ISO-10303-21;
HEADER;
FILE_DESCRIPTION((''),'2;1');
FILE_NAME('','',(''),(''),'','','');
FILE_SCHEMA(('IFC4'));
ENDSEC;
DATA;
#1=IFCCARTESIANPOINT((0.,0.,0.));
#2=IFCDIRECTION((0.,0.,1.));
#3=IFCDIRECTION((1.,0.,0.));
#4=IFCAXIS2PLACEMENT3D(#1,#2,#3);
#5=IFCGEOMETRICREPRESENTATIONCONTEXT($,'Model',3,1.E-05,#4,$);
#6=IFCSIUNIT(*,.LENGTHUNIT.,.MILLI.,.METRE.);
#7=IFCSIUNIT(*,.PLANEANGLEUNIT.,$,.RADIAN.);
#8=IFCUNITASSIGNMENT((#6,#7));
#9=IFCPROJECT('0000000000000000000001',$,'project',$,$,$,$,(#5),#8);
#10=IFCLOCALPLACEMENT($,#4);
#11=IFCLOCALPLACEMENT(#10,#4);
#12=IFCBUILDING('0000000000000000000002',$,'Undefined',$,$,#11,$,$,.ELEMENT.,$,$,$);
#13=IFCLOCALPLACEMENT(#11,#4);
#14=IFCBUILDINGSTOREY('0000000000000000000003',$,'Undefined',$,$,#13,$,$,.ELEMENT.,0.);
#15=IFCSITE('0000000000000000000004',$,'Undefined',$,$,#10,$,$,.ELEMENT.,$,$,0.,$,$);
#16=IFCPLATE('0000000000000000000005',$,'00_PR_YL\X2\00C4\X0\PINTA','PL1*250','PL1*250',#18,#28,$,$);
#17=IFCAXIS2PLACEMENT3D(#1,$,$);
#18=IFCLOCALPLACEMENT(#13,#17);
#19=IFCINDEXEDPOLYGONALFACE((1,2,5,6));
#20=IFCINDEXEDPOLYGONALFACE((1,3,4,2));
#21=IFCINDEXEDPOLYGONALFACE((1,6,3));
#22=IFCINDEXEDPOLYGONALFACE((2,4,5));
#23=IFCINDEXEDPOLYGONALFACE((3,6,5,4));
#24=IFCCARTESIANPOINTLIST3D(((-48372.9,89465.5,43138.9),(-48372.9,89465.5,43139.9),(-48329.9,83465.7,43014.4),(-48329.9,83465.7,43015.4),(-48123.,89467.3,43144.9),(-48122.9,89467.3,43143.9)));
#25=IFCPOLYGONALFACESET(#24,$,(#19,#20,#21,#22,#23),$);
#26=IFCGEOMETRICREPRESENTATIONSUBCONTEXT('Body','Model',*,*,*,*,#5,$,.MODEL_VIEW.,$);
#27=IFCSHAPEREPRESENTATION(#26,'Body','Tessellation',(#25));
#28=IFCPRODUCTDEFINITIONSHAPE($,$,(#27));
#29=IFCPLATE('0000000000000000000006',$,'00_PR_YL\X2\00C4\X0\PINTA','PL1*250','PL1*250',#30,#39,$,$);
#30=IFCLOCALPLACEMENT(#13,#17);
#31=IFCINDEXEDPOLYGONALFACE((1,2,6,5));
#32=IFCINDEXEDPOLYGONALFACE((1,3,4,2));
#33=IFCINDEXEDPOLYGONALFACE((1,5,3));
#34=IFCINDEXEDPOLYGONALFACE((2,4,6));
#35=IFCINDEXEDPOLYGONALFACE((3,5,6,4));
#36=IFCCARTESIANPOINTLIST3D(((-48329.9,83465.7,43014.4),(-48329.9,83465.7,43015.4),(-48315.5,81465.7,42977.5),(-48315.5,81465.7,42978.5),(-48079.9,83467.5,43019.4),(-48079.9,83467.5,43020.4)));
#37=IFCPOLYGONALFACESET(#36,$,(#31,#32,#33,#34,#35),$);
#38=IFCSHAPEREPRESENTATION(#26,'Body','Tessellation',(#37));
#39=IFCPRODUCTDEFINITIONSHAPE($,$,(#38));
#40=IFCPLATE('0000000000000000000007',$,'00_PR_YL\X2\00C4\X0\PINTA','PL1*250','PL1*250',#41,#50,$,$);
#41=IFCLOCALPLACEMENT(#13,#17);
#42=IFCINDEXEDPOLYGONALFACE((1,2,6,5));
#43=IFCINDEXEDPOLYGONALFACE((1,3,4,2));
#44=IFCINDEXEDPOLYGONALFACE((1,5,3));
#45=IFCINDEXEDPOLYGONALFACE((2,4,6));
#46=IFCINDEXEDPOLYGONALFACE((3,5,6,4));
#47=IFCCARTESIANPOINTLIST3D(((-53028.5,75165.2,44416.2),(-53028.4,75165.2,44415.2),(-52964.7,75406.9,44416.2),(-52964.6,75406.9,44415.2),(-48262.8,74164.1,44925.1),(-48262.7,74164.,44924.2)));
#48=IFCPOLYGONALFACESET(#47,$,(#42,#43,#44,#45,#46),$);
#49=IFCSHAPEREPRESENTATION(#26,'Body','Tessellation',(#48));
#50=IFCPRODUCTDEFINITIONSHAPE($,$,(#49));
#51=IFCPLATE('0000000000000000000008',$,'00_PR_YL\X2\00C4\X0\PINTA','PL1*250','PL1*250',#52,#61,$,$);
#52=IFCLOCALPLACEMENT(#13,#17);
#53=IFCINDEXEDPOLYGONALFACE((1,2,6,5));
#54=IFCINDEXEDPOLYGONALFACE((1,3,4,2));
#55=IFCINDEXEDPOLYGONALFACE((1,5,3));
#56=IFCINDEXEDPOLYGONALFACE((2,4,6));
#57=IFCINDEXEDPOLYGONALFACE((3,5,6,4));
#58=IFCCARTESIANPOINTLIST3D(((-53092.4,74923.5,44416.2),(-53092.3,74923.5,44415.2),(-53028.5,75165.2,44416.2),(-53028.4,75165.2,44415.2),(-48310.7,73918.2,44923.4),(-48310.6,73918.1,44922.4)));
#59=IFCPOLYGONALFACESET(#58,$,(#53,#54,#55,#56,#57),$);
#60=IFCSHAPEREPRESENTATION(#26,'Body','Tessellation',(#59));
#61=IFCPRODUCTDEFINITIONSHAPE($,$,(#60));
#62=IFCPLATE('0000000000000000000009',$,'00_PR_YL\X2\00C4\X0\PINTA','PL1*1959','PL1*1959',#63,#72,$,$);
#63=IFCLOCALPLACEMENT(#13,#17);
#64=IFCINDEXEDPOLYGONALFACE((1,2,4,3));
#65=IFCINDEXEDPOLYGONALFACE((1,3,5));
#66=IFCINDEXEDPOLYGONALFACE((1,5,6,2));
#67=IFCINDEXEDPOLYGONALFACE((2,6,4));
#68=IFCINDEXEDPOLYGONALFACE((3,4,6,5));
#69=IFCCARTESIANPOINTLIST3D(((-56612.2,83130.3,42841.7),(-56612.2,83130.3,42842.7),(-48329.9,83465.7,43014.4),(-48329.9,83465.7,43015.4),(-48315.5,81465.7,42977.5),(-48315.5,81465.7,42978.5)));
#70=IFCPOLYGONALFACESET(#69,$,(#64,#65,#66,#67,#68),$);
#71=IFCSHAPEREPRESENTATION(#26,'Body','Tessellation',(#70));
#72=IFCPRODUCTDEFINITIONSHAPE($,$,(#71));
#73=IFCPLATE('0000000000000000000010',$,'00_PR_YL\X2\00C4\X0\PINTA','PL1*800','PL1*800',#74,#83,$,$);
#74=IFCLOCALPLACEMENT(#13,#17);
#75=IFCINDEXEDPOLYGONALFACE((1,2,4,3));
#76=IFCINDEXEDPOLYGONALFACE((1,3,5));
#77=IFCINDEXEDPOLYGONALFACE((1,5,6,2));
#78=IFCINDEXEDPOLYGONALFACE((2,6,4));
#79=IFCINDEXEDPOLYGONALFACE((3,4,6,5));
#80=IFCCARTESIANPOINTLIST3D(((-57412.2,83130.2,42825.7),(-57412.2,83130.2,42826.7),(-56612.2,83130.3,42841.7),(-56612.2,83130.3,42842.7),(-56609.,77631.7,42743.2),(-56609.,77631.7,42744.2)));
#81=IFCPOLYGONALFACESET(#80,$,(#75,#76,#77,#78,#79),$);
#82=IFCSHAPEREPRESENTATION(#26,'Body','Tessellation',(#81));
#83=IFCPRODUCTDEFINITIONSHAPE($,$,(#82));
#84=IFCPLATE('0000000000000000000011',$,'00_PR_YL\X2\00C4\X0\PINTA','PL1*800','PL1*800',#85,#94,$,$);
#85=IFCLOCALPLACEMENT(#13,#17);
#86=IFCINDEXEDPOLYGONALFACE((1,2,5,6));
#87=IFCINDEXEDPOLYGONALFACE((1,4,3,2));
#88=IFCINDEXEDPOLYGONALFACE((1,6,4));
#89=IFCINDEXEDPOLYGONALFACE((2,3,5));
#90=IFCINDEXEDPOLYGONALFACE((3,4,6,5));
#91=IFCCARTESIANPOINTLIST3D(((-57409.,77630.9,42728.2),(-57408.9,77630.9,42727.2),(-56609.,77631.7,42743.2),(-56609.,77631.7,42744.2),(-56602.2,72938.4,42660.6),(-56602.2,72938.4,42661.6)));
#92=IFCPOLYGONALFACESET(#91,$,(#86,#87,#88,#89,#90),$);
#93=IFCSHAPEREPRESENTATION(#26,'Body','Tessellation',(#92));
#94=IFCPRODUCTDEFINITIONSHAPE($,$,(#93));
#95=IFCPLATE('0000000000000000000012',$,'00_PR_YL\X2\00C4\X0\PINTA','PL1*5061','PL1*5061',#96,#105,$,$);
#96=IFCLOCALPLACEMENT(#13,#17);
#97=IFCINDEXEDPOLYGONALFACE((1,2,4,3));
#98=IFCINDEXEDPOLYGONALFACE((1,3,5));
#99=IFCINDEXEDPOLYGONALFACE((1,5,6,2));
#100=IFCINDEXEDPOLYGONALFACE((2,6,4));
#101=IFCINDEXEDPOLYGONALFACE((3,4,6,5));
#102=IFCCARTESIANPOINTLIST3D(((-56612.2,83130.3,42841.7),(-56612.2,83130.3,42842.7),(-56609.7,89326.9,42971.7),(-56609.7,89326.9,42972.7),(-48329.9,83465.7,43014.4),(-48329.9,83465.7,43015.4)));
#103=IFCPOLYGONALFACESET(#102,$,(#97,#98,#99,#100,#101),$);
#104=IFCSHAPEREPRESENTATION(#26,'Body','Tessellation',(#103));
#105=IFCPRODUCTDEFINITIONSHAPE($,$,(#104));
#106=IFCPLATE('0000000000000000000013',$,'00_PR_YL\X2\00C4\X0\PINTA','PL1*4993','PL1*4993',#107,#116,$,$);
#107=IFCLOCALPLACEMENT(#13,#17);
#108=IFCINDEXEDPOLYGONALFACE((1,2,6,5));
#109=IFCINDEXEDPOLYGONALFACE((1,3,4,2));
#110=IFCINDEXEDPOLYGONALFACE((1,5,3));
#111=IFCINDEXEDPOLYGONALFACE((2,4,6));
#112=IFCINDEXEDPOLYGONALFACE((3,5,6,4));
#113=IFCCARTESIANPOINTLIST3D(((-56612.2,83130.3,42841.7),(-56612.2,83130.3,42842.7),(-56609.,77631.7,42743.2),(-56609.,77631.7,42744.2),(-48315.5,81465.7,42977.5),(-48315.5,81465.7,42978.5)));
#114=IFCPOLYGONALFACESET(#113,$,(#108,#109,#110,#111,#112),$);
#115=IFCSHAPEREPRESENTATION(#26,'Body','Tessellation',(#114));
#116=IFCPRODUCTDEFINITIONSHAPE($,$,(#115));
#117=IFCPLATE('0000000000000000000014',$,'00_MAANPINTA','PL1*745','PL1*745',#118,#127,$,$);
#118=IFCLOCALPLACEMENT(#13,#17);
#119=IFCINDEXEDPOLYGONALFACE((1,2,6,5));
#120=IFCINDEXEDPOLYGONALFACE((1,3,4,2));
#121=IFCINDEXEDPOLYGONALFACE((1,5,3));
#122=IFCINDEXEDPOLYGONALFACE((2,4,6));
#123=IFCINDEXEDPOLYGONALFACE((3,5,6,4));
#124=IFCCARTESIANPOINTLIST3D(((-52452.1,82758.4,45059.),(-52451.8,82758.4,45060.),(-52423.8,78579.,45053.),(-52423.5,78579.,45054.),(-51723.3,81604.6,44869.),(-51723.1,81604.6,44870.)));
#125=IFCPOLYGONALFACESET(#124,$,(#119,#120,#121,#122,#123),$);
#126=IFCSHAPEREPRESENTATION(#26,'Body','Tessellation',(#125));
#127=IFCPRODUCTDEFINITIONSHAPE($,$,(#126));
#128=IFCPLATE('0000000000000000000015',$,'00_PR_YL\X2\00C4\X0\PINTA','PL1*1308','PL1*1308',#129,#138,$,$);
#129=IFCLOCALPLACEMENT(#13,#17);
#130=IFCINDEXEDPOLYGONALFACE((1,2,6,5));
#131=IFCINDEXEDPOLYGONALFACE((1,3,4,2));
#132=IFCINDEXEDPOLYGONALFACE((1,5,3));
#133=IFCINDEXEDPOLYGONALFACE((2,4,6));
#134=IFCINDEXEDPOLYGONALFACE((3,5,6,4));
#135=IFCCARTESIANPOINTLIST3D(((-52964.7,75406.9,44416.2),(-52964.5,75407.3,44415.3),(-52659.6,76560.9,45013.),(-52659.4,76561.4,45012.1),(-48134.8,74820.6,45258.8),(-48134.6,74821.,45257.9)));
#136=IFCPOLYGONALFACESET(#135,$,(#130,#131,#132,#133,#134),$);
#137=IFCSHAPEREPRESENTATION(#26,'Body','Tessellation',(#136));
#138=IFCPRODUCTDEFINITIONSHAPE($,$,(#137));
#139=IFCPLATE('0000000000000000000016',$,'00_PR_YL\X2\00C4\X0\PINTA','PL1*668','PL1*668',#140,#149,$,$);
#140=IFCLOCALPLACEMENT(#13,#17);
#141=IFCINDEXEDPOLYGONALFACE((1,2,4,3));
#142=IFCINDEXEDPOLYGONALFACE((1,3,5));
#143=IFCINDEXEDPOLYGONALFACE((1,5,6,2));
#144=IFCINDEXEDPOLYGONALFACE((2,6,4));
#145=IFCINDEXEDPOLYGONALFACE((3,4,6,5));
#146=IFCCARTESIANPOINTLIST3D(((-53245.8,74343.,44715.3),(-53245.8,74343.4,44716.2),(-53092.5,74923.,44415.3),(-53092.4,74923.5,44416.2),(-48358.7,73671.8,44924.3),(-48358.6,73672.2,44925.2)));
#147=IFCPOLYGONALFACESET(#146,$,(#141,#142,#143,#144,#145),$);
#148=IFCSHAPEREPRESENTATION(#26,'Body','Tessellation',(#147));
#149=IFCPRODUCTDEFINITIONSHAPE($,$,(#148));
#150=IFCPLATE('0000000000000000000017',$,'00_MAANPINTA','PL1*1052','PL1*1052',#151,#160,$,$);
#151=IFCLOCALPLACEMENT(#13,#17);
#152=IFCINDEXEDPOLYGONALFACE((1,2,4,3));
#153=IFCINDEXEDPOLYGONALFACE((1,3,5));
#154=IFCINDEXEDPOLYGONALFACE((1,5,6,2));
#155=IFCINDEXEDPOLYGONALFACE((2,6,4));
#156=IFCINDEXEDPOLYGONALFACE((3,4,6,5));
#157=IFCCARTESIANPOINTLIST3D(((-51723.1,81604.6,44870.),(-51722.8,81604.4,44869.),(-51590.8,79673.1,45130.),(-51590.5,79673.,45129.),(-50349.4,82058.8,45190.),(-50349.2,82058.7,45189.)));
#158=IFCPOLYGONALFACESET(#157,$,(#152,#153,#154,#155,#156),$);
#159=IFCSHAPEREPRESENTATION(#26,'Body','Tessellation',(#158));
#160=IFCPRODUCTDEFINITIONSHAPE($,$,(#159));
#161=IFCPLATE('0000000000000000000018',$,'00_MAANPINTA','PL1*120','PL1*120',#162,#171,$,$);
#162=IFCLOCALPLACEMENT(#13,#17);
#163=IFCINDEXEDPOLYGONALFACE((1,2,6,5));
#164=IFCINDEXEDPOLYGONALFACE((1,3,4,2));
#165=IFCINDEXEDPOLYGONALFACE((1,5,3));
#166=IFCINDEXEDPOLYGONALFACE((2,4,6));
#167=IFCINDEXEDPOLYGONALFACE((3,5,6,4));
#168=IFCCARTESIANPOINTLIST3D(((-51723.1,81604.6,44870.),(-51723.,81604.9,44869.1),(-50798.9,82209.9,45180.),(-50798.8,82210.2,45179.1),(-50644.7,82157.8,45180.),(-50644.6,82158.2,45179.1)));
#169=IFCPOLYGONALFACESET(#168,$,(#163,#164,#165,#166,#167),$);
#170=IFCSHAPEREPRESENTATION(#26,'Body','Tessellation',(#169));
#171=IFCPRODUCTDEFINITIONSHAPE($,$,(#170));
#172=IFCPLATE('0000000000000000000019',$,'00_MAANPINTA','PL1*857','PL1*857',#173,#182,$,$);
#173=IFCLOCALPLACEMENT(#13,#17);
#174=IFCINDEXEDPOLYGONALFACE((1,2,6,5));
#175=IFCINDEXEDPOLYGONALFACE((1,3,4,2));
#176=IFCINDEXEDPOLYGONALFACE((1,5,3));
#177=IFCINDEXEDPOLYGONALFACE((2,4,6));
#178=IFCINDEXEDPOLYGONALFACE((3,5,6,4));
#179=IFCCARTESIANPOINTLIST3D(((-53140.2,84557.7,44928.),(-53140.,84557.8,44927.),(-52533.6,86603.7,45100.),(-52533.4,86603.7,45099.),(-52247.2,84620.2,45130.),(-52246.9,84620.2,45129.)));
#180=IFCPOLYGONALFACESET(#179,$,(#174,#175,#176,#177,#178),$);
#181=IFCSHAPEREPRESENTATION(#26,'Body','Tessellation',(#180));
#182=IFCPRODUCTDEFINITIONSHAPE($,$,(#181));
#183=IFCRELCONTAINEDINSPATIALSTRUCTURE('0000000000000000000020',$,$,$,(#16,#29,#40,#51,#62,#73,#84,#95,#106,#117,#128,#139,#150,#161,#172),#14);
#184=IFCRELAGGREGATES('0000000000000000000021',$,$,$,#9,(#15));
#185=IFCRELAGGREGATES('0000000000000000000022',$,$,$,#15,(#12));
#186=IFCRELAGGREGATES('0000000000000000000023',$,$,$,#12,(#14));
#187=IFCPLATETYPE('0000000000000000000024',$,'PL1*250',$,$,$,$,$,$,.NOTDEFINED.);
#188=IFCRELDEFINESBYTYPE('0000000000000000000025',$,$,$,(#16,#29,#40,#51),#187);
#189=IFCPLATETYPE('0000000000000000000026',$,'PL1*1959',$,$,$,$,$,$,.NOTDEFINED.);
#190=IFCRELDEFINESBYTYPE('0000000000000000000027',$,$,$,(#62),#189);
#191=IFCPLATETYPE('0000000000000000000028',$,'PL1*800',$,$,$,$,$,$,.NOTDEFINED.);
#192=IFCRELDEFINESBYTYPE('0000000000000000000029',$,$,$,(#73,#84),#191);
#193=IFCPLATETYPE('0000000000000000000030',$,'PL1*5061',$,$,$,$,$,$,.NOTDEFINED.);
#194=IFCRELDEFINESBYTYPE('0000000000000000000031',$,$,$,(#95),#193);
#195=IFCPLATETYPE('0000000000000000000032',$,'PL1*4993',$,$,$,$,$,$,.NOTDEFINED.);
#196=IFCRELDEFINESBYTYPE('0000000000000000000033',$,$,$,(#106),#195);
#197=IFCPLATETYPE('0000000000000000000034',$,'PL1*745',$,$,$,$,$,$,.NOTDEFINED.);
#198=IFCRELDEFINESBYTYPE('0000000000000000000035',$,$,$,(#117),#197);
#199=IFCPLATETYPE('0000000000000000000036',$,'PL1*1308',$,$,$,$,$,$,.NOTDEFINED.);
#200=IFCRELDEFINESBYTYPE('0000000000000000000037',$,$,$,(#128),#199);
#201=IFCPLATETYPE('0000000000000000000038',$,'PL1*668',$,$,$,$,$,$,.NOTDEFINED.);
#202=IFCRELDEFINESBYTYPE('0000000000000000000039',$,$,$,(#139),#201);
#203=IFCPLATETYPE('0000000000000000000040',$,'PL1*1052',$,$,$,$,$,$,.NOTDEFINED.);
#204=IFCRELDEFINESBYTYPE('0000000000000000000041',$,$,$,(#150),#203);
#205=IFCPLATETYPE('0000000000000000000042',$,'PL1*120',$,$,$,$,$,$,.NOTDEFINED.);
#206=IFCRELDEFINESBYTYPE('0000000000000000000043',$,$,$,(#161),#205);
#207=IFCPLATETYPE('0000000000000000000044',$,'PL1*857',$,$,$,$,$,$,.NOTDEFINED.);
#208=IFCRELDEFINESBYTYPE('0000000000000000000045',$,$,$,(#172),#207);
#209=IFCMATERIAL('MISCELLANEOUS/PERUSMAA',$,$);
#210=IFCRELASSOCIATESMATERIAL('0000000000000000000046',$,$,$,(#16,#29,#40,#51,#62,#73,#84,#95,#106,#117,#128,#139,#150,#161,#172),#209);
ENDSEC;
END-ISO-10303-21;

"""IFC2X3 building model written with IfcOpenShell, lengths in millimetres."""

from ifc_helpers import new_model, si_unit, frame, origin_with_axes, place, context, subcontext, project, spatial, polyline, outline, extrude, material, type_object, element, save


model = new_model("IFC2X3")

# Units and contexts
model_context = context("Model", 3, precision=1e-05, world=origin_with_axes())
body_context = subcontext(model_context, "Body", "Model", "MODEL_VIEW")
ifc_project = project(units=[si_unit("LENGTHUNIT", "METRE", prefix="MILLI"), si_unit("PLANEANGLEUNIT", "RADIAN")], contexts=[model_context])

# Site, building, storey
site_placement = place(None, origin_with_axes())
site = spatial("IfcSite", under=ifc_project, at=site_placement, Name="Undefined", CompositionType="ELEMENT", RefElevation=0.0)
building_placement = place(site_placement, origin_with_axes())
building = spatial("IfcBuilding", under=site, at=building_placement, Name="Undefined", CompositionType="ELEMENT")
storey_placement = place(building_placement, origin_with_axes())
storey = spatial("IfcBuildingStorey", under=building, at=storey_placement, Name="Undefined", CompositionType="ELEMENT", Elevation=0.0)

# Plates
ifc_material = material(Name="MISCELLANEOUS/PERUSMAA")
plate_type_1 = type_object("IfcPlateType", Name="PL1*250", PredefinedType="NOTDEFINED")
plate_1_placement = place(storey_placement, frame((-48329.9, 83465.7, 43014.9), z_axis=(0.019842, 0.020894, -0.999585), x_axis=(-0.007178, 0.999759, 0.020755)))
element("IfcPlate", 1, at=plate_1_placement, inside=storey, type_object=plate_type_1, material=ifc_material, Name="00_PR_YLÄPINTA", Description="PL1*250", ObjectType="PL1*250", context=body_context, shape_type="SweptSolid", body=[
    extrude(outline(polyline([(0.0, 0.0), (6001.3, 0.0), (6001.4, 250.1), (0.0, 0.0)])), frame((0.0, 0.0, -0.5), z_axis=(0.0, 0.0, 1.0), x_axis=(1.0, 0.0, 0.0)), (0.0, 0.0, 1.0), 1.0),
])
plate_2_placement = place(storey_placement, frame((-48315.5, 81465.7, 42978.0), z_axis=(0.01986, 0.018577, -0.99963), x_axis=(-0.007178, 0.999804, 0.018438)))
element("IfcPlate", 2, at=plate_2_placement, inside=storey, type_object=plate_type_1, material=ifc_material, Name="00_PR_YLÄPINTA", Description="PL1*250", ObjectType="PL1*250", context=body_context, shape_type="SweptSolid", body=[
    extrude(outline(polyline([(0.0, 0.0), (2000.3, 0.0), (2000.4, 250.1), (0.0, 0.0)])), frame((0.0, 0.0, -0.5), z_axis=(0.0, 0.0, 1.0), x_axis=(1.0, 0.0, 0.0)), (0.0, 0.0, 1.0), 1.0),
])
plate_3_placement = place(storey_placement, frame((-53028.5, 75165.2, 44415.7), z_axis=(0.100634, -0.0266, -0.994568), x_axis=(0.255547, 0.966797, 0.0)))
element("IfcPlate", 3, at=plate_3_placement, inside=storey, type_object=plate_type_1, material=ifc_material, Name="00_PR_YLÄPINTA", Description="PL1*250", ObjectType="PL1*250", context=body_context, shape_type="SweptSolid", body=[
    extrude(outline(polyline([(0.0, 0.0), (250.0, 0.0), (250.0, 4889.9), (0.0, 0.0)])), frame((0.0, 0.0, -0.5), z_axis=(0.0, 0.0, 1.0), x_axis=(1.0, 0.0, 0.0)), (0.0, 0.0, 1.0), 1.0),
])
plate_4_placement = place(storey_placement, frame((-53092.4, 74923.5, 44415.7), z_axis=(0.099963, -0.026422, -0.99464), x_axis=(0.255544, 0.966798, 0.0)))
element("IfcPlate", 4, at=plate_4_placement, inside=storey, type_object=plate_type_1, material=ifc_material, Name="00_PR_YLÄPINTA", Description="PL1*250", ObjectType="PL1*250", context=body_context, shape_type="SweptSolid", body=[
    extrude(outline(polyline([(0.0, 0.0), (250.0, 0.0), (250.0, 4906.2), (0.0, 0.0)])), frame((0.0, 0.0, -0.5), z_axis=(0.0, 0.0, 1.0), x_axis=(1.0, 0.0, 0.0)), (0.0, 0.0, 1.0), 1.0),
])
plate_type_2 = type_object("IfcPlateType", Name="PL1*1959", PredefinedType="NOTDEFINED")
plate_5_placement = place(storey_placement, frame((-48329.9, 83465.7, 43014.9), z_axis=(0.020081, 0.018579, -0.999626), x_axis=(0.007178, -0.999804, -0.018438)))
element("IfcPlate", 5, at=plate_5_placement, inside=storey, type_object=plate_type_2, material=ifc_material, Name="00_PR_YLÄPINTA", Description="PL1*1959", ObjectType="PL1*1959", context=body_context, shape_type="SweptSolid", body=[
    extrude(outline(polyline([(0.0, 0.0), (2000.3, 0.0), (279.1, 8286.2), (0.0, 0.0)])), frame((0.0, 0.0, -0.5), z_axis=(0.0, 0.0, 1.0), x_axis=(1.0, 0.0, 0.0)), (0.0, 0.0, 1.0), 1.0),
])
plate_type_3 = type_object("IfcPlateType", Name="PL1*800", PredefinedType="NOTDEFINED")
plate_6_placement = place(storey_placement, frame((-56612.2, 83130.3, 42842.2), z_axis=(0.019991, 0.017926, -0.999639), x_axis=(0.000582, -0.999839, -0.017918)))
element("IfcPlate", 6, at=plate_6_placement, inside=storey, type_object=plate_type_3, material=ifc_material, Name="00_PR_YLÄPINTA", Description="PL1*800", ObjectType="PL1*800", context=body_context, shape_type="SweptSolid", body=[
    extrude(outline(polyline([(0.0, 0.0), (5499.4, 0.0), (-0.1, 800.2), (0.0, 0.0)])), frame((0.0, 0.0, -0.5), z_axis=(0.0, 0.0, 1.0), x_axis=(1.0, 0.0, 0.0)), (0.0, 0.0, 1.0), 1.0),
])
plate_7_placement = place(storey_placement, frame((-56609.0, 77631.7, 42743.7), z_axis=(0.019975, 0.017631, -0.999645), x_axis=(0.001434, -0.999844, -0.017606)))
element("IfcPlate", 7, at=plate_7_placement, inside=storey, type_object=plate_type_3, material=ifc_material, Name="00_PR_YLÄPINTA", Description="PL1*800", ObjectType="PL1*800", context=body_context, shape_type="SweptSolid", body=[
    extrude(outline(polyline([(0.0, 0.0), (4694.1, 0.0), (0.0, 800.2), (0.0, 0.0)])), frame((0.0, 0.0, -0.5), z_axis=(0.0, 0.0, 1.0), x_axis=(1.0, 0.0, 0.0)), (0.0, 0.0, 1.0), 1.0),
])
plate_type_4 = type_object("IfcPlateType", Name="PL1*5061", PredefinedType="NOTDEFINED")
plate_8_placement = place(storey_placement, frame((-56612.2, 83130.3, 42842.2), z_axis=(0.019983, 0.020961, -0.999581), x_axis=(0.000396, 0.99978, 0.020973)))
element("IfcPlate", 8, at=plate_8_placement, inside=storey, type_object=plate_type_4, material=ifc_material, Name="00_PR_YLÄPINTA", Description="PL1*5061", ObjectType="PL1*5061", context=body_context, shape_type="SweptSolid", body=[
    extrude(outline(polyline([(0.0, 0.0), (6198.0, 0.0), (342.2, 8283.8), (0.0, 0.0)])), frame((0.0, 0.0, -0.5), z_axis=(0.0, 0.0, 1.0), x_axis=(1.0, 0.0, 0.0)), (0.0, 0.0, 1.0), 1.0),
])
plate_type_5 = type_object("IfcPlateType", Name="PL1*4993", PredefinedType="NOTDEFINED")
plate_9_placement = place(storey_placement, frame((-56609.0, 77631.7, 42743.7), z_axis=(0.01995, 0.017926, -0.99964), x_axis=(-0.000582, 0.999839, 0.017918)))
element("IfcPlate", 9, at=plate_9_placement, inside=storey, type_object=plate_type_5, material=ifc_material, Name="00_PR_YLÄPINTA", Description="PL1*4993", ObjectType="PL1*4993", context=body_context, shape_type="SweptSolid", body=[
    extrude(outline(polyline([(0.0, 0.0), (5499.4, 0.0), (3832.8, 8297.3), (0.0, 0.0)])), frame((0.0, 0.0, -0.5), z_axis=(0.0, 0.0, 1.0), x_axis=(1.0, 0.0, 0.0)), (0.0, 0.0, 1.0), 1.0),
])
plate_type_6 = type_object("IfcPlateType", Name="PL1*745", PredefinedType="NOTDEFINED")
plate_10_placement = place(storey_placement, frame((-51723.2, 81604.6, 44869.5), z_axis=(-0.252758, -0.000325, -0.96753), x_axis=(-0.225146, -0.972528, 0.059144)))
element("IfcPlate", 10, at=plate_10_placement, inside=storey, type_object=plate_type_6, material=ifc_material, Name="00_MAANPINTA", Description="PL1*745", ObjectType="PL1*745", context=body_context, shape_type="SweptSolid", body=[
    extrude(outline(polyline([(0.0, 0.0), (3111.0, 0.0), (-946.8, 1001.1), (0.0, 0.0)])), frame((0.0, 0.0, -0.5), z_axis=(0.0, 0.0, 1.0), x_axis=(1.0, 0.0, 0.0)), (0.0, 0.0, 1.0), 1.0),
])
plate_type_7 = type_object("IfcPlateType", Name="PL1*1308", PredefinedType="NOTDEFINED")
plate_11_placement = place(storey_placement, frame((-52964.6, 75407.1, 44415.7), z_axis=(0.2047, 0.406416, -0.890463), x_axis=(0.228566, 0.86473, 0.447213)))
element("IfcPlate", 11, at=plate_11_placement, inside=storey, type_object=plate_type_7, material=ifc_material, Name="00_PR_YLÄPINTA", Description="PL1*1308", ObjectType="PL1*1308", context=body_context, shape_type="SweptSolid", body=[
    extrude(outline(polyline([(0.0, 0.0), (1334.6, 0.0), (973.8, 4840.8), (0.0, 0.0)])), frame((0.0, 0.0, -0.5), z_axis=(0.0, 0.0, 1.0), x_axis=(1.0, 0.0, 0.0)), (0.0, 0.0, 1.0), 1.0),
])
plate_type_8 = type_object("IfcPlateType", Name="PL1*668", PredefinedType="NOTDEFINED")
plate_12_placement = place(storey_placement, frame((-53245.8, 74343.2, 44715.7), z_axis=(-0.024284, -0.454167, -0.890586), x_axis=(0.228565, 0.86473, -0.447214)))
element("IfcPlate", 12, at=plate_12_placement, inside=storey, type_object=plate_type_8, material=ifc_material, Name="00_PR_YLÄPINTA", Description="PL1*668", ObjectType="PL1*668", context=body_context, shape_type="SweptSolid", body=[
    extrude(outline(polyline([(0.0, 0.0), (670.8, 0.0), (443.2, 4917.5), (0.0, 0.0)])), frame((0.0, 0.0, -0.5), z_axis=(0.0, 0.0, 1.0), x_axis=(1.0, 0.0, 0.0)), (0.0, 0.0, 1.0), 1.0),
])
plate_type_9 = type_object("IfcPlateType", Name="PL1*1052", PredefinedType="NOTDEFINED")
plate_13_placement = place(storey_placement, frame((-50349.3, 82058.7, 45189.5), z_axis=(0.260231, -0.111289, -0.959111), x_axis=(-0.461482, -0.886869, -0.022305)))
element("IfcPlate", 13, at=plate_13_placement, inside=storey, type_object=plate_type_9, material=ifc_material, Name="00_MAANPINTA", Description="PL1*1052", ObjectType="PL1*1052", context=body_context, shape_type="SweptSolid", body=[
    extrude(outline(polyline([(0.0, 0.0), (2690.0, 0.0), (1043.9, 1051.6), (0.0, 0.0)])), frame((0.0, 0.0, -0.5), z_axis=(0.0, 0.0, 1.0), x_axis=(1.0, 0.0, 0.0)), (0.0, 0.0, 1.0), 1.0),
])
plate_type_10 = type_object("IfcPlateType", Name="PL1*120", PredefinedType="NOTDEFINED")
plate_14_placement = place(storey_placement, frame((-51723.0, 81604.7, 44869.5), z_axis=(0.107479, 0.318256, -0.941892), x_axis=(0.805399, 0.527581, 0.270169)))
element("IfcPlate", 14, at=plate_14_placement, inside=storey, type_object=plate_type_10, material=ifc_material, Name="00_MAANPINTA", Description="PL1*120", ObjectType="PL1*120", context=body_context, shape_type="SweptSolid", body=[
    extrude(outline(polyline([(0.0, 0.0), (1147.4, 0.0), (1244.2, 130.9), (0.0, 0.0)])), frame((0.0, 0.0, -0.5), z_axis=(0.0, 0.0, 1.0), x_axis=(1.0, 0.0, 0.0)), (0.0, 0.0, 1.0), 1.0),
])
plate_type_11 = type_object("IfcPlateType", Name="PL1*857", PredefinedType="NOTDEFINED")
plate_15_placement = place(storey_placement, frame((-52247.0, 84620.2, 45129.5), z_axis=(0.219466, 0.016945, -0.975473), x_axis=(-0.9731, -0.068014, -0.220114)))
element("IfcPlate", 15, at=plate_15_placement, inside=storey, type_object=plate_type_11, material=ifc_material, Name="00_MAANPINTA", Description="PL1*857", ObjectType="PL1*857", context=body_context, shape_type="SweptSolid", body=[
    extrude(outline(polyline([(0.0, 0.0), (917.7, 0.0), (150.5, 1998.7), (0.0, 0.0)])), frame((0.0, 0.0, -0.5), z_axis=(0.0, 0.0, 1.0), x_axis=(1.0, 0.0, 0.0)), (0.0, 0.0, 1.0), 1.0),
])

save(model, "model.ifc")
